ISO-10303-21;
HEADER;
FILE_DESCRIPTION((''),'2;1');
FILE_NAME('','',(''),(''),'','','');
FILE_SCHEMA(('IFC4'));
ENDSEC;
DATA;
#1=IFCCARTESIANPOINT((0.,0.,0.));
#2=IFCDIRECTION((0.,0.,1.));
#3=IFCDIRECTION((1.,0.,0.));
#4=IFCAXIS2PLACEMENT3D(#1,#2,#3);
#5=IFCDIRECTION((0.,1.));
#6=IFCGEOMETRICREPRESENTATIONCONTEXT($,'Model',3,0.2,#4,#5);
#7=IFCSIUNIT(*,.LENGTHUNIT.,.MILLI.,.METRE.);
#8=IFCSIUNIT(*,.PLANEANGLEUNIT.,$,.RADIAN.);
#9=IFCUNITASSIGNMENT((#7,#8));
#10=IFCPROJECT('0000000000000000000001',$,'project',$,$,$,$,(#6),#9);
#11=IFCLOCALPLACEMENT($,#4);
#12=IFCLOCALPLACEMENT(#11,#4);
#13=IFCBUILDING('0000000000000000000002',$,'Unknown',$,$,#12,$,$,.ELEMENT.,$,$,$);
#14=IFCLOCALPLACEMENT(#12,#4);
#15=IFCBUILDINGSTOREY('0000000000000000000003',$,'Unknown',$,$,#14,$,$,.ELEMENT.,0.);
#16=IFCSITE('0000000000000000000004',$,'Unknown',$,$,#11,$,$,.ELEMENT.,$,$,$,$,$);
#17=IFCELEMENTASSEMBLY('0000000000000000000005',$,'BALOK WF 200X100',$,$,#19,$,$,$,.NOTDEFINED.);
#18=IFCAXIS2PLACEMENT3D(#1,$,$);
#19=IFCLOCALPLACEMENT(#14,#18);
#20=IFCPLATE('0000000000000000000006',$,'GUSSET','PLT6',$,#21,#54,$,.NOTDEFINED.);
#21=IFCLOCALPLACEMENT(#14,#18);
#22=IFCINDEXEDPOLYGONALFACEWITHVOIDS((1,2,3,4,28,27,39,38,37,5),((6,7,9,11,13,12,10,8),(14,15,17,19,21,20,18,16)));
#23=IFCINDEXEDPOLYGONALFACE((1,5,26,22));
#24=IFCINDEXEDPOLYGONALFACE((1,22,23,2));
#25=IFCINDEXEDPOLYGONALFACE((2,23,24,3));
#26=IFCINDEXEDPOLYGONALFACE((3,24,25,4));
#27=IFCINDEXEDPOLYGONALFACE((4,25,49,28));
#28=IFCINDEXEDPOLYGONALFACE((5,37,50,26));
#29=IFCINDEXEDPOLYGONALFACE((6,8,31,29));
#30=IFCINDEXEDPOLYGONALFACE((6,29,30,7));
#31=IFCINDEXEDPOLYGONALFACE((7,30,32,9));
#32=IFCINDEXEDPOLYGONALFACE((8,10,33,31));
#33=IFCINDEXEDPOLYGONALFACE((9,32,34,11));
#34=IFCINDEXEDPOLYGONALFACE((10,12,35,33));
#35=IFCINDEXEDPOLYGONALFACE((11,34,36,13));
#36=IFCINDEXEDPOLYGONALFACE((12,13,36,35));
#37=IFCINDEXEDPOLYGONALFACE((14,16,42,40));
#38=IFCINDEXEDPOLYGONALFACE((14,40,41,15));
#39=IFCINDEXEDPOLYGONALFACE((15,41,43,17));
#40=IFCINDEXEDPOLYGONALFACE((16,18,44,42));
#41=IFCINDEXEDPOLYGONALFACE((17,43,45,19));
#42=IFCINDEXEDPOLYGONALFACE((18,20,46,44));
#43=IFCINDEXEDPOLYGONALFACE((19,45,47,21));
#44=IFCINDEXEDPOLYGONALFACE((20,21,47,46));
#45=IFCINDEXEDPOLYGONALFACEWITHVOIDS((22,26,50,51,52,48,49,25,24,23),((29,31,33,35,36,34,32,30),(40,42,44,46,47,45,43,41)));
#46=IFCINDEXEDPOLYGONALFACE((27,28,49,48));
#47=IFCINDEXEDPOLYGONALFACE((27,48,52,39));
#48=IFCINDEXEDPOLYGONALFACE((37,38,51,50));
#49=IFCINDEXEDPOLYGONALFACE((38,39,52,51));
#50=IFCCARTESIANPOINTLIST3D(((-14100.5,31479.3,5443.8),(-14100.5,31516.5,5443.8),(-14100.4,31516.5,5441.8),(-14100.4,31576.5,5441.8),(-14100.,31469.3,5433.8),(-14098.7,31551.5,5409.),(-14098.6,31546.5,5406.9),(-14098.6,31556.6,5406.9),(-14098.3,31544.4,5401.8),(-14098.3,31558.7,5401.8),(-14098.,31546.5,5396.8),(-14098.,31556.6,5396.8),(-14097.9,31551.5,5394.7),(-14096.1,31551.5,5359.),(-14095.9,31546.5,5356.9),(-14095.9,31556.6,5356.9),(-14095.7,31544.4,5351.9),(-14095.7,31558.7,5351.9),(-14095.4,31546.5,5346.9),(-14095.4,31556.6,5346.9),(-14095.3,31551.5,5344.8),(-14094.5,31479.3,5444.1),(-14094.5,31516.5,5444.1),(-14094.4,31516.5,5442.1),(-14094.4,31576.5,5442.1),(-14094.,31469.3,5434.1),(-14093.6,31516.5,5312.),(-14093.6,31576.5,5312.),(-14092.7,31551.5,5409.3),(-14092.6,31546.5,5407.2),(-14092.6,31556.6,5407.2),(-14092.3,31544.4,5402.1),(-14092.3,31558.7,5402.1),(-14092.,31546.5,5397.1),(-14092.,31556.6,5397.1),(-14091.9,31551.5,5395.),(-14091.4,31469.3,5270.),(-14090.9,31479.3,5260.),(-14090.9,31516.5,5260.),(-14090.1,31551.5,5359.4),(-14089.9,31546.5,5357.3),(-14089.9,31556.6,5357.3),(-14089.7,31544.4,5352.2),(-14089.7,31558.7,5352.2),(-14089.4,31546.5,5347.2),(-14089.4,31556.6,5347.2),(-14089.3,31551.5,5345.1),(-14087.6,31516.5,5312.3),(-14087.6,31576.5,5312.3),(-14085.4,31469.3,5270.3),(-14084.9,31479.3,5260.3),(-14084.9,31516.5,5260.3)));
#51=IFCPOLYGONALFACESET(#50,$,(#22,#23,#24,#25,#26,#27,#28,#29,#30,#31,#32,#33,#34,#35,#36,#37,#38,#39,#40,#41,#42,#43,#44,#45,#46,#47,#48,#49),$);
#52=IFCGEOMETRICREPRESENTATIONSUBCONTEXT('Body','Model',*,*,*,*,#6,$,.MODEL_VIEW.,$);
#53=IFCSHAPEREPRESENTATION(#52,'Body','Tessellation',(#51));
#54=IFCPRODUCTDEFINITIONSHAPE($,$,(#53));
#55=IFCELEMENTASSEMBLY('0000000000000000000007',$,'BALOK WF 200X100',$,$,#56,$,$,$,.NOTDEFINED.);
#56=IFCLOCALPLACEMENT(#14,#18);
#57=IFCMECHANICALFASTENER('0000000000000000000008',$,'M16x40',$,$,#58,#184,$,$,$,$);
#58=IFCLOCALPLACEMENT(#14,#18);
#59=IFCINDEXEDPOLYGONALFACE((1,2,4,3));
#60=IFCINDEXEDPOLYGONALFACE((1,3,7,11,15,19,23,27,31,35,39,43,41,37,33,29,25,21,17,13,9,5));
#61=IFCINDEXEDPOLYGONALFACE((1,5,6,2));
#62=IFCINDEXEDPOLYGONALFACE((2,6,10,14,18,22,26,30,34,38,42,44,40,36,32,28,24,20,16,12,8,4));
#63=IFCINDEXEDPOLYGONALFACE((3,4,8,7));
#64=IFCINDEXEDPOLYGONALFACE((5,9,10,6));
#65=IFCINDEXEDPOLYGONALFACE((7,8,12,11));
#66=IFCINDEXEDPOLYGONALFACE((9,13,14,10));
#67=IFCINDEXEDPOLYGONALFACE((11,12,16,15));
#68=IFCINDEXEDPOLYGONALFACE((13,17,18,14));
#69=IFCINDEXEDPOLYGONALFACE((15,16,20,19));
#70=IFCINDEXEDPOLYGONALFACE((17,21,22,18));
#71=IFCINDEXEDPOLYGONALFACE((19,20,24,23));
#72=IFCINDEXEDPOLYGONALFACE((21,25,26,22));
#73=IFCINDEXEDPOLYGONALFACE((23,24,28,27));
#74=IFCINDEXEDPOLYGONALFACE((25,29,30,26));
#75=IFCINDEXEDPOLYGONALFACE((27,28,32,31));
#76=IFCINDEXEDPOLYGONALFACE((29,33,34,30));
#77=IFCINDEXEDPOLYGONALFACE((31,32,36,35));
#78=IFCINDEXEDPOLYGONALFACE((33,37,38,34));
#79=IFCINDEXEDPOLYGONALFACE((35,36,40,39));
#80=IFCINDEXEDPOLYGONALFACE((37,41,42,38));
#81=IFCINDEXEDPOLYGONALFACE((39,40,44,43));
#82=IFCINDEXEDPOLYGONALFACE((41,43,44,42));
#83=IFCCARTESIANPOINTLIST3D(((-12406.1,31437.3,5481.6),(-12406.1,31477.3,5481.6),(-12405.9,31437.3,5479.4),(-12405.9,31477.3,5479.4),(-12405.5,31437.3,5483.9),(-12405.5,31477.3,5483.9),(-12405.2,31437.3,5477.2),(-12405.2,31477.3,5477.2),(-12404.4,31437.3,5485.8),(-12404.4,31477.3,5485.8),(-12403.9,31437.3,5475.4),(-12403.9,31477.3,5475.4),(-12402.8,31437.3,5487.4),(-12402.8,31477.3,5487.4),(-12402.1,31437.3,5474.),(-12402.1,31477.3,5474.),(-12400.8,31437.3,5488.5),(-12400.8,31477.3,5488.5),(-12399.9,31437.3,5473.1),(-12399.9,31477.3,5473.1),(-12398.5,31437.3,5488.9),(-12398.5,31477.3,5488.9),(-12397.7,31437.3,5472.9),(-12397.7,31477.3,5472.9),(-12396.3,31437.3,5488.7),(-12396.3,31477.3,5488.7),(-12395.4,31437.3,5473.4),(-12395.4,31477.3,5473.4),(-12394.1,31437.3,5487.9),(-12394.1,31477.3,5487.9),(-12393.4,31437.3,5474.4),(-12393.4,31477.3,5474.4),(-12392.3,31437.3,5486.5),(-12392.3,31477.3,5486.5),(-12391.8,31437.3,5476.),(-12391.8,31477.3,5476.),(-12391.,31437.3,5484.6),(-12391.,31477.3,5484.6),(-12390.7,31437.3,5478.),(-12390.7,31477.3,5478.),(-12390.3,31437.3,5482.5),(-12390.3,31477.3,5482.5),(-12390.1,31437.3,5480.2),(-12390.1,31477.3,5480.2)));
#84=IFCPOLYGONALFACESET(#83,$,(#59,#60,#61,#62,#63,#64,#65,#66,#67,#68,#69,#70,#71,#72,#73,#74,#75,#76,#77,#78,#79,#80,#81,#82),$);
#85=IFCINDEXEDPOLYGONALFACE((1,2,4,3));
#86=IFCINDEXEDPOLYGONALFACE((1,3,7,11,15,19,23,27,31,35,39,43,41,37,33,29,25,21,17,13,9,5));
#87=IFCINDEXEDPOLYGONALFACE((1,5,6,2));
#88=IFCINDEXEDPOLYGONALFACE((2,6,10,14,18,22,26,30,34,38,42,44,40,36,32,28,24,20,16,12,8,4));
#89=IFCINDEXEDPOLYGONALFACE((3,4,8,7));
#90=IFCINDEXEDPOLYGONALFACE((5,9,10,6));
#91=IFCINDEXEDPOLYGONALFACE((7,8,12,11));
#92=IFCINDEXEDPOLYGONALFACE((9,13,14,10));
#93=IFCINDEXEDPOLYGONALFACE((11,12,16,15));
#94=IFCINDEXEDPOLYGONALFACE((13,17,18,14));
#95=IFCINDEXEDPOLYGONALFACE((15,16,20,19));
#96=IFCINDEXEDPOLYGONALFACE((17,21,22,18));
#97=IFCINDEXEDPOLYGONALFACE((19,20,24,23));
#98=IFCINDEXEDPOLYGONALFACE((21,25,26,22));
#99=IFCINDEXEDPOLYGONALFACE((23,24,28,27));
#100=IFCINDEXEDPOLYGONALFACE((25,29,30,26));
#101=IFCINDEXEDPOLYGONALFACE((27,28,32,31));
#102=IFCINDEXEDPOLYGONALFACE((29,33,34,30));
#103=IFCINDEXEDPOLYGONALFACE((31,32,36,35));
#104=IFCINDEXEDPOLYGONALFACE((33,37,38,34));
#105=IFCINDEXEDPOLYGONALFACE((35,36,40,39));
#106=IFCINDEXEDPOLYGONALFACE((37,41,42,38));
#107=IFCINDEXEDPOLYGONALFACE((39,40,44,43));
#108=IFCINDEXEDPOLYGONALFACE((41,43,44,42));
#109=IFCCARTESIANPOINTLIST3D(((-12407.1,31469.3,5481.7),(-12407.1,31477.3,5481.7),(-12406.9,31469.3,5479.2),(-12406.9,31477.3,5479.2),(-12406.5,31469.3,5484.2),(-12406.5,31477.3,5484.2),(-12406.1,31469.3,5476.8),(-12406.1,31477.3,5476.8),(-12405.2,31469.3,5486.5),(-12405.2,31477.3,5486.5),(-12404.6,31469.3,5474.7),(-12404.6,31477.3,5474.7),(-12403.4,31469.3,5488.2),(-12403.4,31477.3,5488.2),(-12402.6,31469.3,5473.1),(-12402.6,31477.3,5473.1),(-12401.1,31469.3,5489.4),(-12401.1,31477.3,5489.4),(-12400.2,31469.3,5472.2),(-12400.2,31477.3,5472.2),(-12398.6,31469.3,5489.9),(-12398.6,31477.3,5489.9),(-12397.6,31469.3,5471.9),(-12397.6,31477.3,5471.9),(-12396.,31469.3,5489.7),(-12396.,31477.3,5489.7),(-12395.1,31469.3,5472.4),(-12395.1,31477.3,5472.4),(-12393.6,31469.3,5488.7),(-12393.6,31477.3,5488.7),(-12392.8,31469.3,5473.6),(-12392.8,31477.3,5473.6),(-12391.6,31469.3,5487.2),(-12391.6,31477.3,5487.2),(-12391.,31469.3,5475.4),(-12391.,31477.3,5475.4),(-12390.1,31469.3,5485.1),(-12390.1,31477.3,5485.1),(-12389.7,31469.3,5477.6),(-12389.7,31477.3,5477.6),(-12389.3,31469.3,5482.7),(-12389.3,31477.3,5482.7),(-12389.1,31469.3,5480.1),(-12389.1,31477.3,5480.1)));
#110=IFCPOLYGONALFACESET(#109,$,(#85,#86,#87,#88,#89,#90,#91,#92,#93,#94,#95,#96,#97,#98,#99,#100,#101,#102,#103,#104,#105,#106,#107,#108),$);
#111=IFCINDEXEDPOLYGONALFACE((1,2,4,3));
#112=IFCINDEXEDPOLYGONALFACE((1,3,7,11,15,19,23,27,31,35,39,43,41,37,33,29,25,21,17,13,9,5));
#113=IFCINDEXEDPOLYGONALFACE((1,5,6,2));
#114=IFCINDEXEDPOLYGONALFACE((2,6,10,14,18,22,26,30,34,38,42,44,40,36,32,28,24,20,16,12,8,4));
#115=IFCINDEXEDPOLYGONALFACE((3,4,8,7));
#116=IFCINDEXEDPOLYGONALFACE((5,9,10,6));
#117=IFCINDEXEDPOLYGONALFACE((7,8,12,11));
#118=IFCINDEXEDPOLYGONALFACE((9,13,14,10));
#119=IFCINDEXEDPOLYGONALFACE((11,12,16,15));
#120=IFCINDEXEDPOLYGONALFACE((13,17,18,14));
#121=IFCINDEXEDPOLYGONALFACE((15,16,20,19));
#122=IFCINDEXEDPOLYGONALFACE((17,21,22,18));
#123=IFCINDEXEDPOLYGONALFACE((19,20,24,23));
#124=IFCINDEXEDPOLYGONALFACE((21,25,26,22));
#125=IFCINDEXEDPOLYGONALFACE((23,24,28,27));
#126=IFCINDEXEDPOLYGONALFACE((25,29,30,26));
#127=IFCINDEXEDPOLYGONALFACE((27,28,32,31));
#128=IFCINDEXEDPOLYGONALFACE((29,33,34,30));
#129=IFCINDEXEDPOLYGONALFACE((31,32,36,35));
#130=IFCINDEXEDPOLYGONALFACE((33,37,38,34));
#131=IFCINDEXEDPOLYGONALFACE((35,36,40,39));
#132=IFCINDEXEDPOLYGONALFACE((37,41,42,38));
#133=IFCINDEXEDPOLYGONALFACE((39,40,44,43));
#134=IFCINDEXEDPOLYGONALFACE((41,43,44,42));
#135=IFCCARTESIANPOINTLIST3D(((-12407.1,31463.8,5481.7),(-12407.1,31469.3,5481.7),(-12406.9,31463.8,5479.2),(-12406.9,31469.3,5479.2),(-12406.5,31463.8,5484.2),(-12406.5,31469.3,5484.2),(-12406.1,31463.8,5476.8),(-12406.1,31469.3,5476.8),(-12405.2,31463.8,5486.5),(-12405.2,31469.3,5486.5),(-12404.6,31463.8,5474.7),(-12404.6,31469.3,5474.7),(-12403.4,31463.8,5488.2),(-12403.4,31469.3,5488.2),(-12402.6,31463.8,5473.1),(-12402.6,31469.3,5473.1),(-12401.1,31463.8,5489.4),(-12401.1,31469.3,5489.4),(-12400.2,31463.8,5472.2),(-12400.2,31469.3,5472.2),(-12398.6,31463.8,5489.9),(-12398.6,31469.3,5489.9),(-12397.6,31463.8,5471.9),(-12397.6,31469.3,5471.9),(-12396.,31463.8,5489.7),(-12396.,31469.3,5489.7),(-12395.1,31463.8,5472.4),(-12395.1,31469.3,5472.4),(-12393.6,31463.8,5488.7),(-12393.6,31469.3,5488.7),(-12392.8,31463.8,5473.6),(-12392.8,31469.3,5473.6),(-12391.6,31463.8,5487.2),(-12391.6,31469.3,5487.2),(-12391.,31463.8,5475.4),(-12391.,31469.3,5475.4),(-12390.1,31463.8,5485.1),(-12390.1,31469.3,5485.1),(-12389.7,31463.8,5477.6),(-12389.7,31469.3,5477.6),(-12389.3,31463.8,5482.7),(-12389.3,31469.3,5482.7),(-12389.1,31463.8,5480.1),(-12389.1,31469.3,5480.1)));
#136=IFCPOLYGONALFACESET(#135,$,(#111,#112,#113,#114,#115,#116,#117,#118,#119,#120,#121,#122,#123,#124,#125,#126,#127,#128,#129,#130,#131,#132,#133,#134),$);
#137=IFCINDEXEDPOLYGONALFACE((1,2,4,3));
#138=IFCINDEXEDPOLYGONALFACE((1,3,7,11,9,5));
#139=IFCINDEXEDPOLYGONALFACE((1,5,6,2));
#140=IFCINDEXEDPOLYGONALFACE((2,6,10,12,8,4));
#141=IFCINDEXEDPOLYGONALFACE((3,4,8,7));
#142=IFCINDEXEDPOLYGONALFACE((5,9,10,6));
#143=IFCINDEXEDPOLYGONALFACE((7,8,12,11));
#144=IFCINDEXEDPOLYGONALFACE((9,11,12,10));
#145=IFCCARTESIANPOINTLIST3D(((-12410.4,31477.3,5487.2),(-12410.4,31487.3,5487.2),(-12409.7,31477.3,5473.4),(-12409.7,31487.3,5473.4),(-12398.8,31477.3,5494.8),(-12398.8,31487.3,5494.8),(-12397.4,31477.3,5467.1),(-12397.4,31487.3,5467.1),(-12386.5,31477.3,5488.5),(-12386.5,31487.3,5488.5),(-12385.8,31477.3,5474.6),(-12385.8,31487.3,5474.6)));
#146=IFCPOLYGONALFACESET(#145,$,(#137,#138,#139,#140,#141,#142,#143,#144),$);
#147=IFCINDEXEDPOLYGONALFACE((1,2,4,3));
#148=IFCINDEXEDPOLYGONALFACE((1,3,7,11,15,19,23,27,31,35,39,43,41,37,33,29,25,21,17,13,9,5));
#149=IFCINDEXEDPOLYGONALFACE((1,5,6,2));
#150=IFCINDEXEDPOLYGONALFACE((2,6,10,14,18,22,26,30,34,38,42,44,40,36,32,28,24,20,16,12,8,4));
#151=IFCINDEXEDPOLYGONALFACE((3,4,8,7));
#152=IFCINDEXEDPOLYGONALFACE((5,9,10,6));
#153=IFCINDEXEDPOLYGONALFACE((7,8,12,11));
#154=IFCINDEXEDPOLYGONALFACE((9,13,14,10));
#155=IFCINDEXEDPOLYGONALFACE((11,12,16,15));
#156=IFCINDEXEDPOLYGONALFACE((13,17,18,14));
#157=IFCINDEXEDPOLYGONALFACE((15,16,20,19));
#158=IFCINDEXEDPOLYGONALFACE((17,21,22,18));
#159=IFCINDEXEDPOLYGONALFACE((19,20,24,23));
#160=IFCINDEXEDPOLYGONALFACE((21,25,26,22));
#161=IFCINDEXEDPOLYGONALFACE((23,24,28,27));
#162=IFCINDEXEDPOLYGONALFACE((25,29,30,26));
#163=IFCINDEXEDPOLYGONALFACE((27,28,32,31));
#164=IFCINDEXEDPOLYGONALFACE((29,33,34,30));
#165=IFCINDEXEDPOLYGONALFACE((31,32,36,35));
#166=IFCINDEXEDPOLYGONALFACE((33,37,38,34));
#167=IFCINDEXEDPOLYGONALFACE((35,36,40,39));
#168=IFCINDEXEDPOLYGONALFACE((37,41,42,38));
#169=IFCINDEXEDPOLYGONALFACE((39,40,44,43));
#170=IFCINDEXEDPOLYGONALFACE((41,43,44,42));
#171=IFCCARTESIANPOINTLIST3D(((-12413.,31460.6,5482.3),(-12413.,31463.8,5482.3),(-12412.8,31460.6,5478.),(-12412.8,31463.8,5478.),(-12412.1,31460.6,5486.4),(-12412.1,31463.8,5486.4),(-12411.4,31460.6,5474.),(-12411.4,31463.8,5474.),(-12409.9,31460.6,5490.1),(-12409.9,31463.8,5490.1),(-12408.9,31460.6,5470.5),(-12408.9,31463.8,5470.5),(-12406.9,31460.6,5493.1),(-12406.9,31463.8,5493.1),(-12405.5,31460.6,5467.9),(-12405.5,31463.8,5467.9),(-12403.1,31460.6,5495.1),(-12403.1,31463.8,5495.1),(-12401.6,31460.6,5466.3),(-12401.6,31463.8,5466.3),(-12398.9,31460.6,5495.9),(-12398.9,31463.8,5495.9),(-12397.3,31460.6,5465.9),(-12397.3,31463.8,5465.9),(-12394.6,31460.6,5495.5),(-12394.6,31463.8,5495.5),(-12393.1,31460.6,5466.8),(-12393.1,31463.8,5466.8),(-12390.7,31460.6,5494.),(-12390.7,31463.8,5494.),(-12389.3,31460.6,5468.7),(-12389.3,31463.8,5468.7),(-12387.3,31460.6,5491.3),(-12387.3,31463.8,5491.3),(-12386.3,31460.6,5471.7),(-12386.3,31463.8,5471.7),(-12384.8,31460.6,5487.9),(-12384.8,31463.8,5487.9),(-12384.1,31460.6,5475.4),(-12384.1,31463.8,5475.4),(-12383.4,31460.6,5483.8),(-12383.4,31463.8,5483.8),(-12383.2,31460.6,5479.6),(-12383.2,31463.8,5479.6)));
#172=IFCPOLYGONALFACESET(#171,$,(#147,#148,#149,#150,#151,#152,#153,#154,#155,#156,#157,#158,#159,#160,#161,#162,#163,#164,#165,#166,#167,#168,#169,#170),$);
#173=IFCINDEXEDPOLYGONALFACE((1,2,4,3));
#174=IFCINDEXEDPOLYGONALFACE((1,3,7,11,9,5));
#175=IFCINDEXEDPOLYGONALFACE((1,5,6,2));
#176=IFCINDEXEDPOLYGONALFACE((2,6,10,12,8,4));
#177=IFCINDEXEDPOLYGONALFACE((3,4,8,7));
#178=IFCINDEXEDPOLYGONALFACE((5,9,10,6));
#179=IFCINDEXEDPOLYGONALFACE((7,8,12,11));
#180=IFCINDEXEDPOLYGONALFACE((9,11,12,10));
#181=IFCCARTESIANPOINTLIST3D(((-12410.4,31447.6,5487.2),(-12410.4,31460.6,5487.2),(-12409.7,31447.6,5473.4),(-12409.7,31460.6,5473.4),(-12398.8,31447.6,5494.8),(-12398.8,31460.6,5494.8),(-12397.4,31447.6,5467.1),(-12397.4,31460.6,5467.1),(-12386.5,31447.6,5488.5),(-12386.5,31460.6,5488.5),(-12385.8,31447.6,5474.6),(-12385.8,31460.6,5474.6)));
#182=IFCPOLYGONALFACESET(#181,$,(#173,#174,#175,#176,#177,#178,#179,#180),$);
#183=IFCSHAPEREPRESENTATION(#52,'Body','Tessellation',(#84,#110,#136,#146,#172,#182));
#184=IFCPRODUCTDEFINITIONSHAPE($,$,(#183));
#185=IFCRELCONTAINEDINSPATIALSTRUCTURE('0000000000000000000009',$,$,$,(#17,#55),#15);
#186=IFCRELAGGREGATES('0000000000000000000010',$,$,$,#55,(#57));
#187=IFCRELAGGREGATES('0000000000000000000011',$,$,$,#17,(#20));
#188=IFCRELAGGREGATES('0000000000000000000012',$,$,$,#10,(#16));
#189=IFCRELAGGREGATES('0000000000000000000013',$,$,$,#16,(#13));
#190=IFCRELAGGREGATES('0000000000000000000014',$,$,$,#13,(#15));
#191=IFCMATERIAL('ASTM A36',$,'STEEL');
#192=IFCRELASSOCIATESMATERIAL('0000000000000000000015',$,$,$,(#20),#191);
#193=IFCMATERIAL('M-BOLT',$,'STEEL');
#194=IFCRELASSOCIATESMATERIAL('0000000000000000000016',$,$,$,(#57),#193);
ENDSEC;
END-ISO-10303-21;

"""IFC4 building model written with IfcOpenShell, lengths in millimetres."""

from ifc_helpers import new_model, si_unit, direction, frame, origin_with_axes, place, context, subcontext, project, spatial, line, arc, indexed_curve, outline, extrude, source, transform, mapped, material, element, aggregate, save


model = new_model("IFC4")

# Units and contexts
model_context = context("Model", 3, precision=0.2, world=origin_with_axes(), true_north=direction((0.0, 1.0)))
body_context = subcontext(model_context, "Body", "Model", "MODEL_VIEW")
ifc_project = project(units=[si_unit("LENGTHUNIT", "METRE", prefix="MILLI"), si_unit("PLANEANGLEUNIT", "RADIAN")], contexts=[model_context])

# Site, building, storey
site_placement = place(None, origin_with_axes())
site = spatial("IfcSite", under=ifc_project, at=site_placement, Name="Unknown", CompositionType="ELEMENT")
building_placement = place(site_placement, origin_with_axes())
building = spatial("IfcBuilding", under=site, at=building_placement, Name="Unknown", CompositionType="ELEMENT")
storey_placement = place(building_placement, origin_with_axes())
storey = spatial("IfcBuildingStorey", under=building, at=storey_placement, Name="Unknown", CompositionType="ELEMENT", Elevation=0.0)

# Element assembly
assembly_1_placement = place(storey_placement, frame((-12608.3, 31466.5, 5421.2), z_axis=(0.0, 1.0, 0.0), x_axis=(-0.998912, 0.0, -0.046636)))
assembly_1 = element("IfcElementAssembly", 1, at=assembly_1_placement, inside=storey, Name="BALOK WF 200X100", PredefinedType="NOTDEFINED")

# Shared definitions
ifc_material_1 = material(Name="ASTM A36", Category="STEEL")

# Plate, voiding features
plate_1_placement = place(assembly_1_placement, frame((1486.5, 92.2, 2.8), z_axis=(0.999984, -0.005707, 0.0), x_axis=(0.0, 0.0, 1.0)))
plate_1 = element("IfcPlate", 2, at=plate_1_placement, material=ifc_material_1, Name="GUSSET", Description="PLT6", PredefinedType="NOTDEFINED", context=body_context, shape_type="SolidModel", body=[
    extrude(outline(indexed_curve([(0.0, 0.0), (47.2, 0.0), (47.2, 2.0), (107.3, 2.0), (107.3, 132.0), (47.2, 132.0), (47.2, 184.0), (0.0, 184.0)], segments=[line(1, 2, 3, 4, 5, 6, 7, 8, 1)])), frame((0.0, 0.0, 3.0), z_axis=(0.0, 0.0, 1.0), x_axis=(1.0, 0.0, 0.0)), (0.0, 0.0, -1.0), 6.0),
])
voiding_feature_1_placement = place(plate_1_placement, frame((10.0, 0.0, 0.0), z_axis=(0.0, 0.0, 1.0), x_axis=(-0.707107, 0.707107, 0.0)))
element("IfcVoidingFeature", 3, at=voiding_feature_1_placement, cuts=plate_1, Name="SLAB", PredefinedType="HOLE", context=body_context, shape_type="SolidModel", body=[
    extrude(outline(indexed_curve([(0.0, 0.0), (14.1, 0.0), (7.1, 7.1)], segments=[line(1, 2, 3, 1)])), frame((0.0, 0.0, 3.0), z_axis=(0.0, 0.0, 1.0), x_axis=(1.0, 0.0, 0.0)), (0.0, 0.0, -1.0), 6.0),
])
voiding_feature_2_placement = place(plate_1_placement, frame((0.0, 174.0, 0.0), z_axis=(0.0, 0.0, 1.0), x_axis=(0.707107, 0.707107, 0.0)))
element("IfcVoidingFeature", 4, at=voiding_feature_2_placement, cuts=plate_1, Name="SLAB", PredefinedType="HOLE", context=body_context, shape_type="SolidModel", body=[
    extrude(outline(indexed_curve([(0.0, 0.0), (14.1, 0.0), (7.1, 7.1)], segments=[line(1, 2, 3, 1)])), frame((0.0, 0.0, 3.0), z_axis=(0.0, 0.0, 1.0), x_axis=(1.0, 0.0, 0.0)), (0.0, 0.0, -1.0), 6.0),
])
voiding_feature_3_placement = place(plate_1_placement, frame((82.3, 92.0, -3.5), z_axis=(-1.0, 0.0, 0.0), x_axis=(0.0, 0.0, 1.0)))
element("IfcVoidingFeature", 5, at=voiding_feature_3_placement, cuts=plate_1, Name="BEAM", PredefinedType="HOLE", context=body_context, shape_type="SolidModel", body=[
    extrude(outline(indexed_curve([(7.1, 0.0), (5.1, 5.1), (0.0, 7.1), (-5.1, 5.1), (-7.1, 0.0), (-5.1, -5.1), (0.0, -7.1), (5.1, -5.1)], segments=[line(1, 2, 3, 4, 5, 6, 7, 8, 1)])), frame((0.0, 0.0, 0.0), z_axis=(-1.0, 0.0, 0.0), x_axis=(0.0, 0.0, 1.0)), (0.0, 0.0, -1.0), 7.0),
])
voiding_feature_4_placement = place(plate_1_placement, frame((82.3, 42.0, -3.5), z_axis=(-1.0, 0.0, 0.0), x_axis=(0.0, 0.0, 1.0)))
element("IfcVoidingFeature", 6, at=voiding_feature_4_placement, cuts=plate_1, Name="BEAM", PredefinedType="HOLE", context=body_context, shape_type="SolidModel", body=[
    extrude(outline(indexed_curve([(7.1, 0.0), (5.1, 5.1), (0.0, 7.1), (-5.1, 5.1), (-7.1, 0.0), (-5.1, -5.1), (0.0, -7.1), (5.1, -5.1)], segments=[line(1, 2, 3, 4, 5, 6, 7, 8, 1)])), frame((0.0, 0.0, 0.0), z_axis=(-1.0, 0.0, 0.0), x_axis=(0.0, 0.0, 1.0)), (0.0, 0.0, -1.0), 7.0),
])

# Element assembly, mechanical fastener
assembly_2_placement = place(storey_placement, frame((-7044.1, 31466.5, 5721.5), z_axis=(0.0, 1.0, 0.0), x_axis=(-0.99863, 0.0, -0.052336)))
assembly_2 = element("IfcElementAssembly", 7, at=assembly_2_placement, inside=storey, Name="BALOK WF 200X100", PredefinedType="NOTDEFINED")
ifc_material_2 = material(Name="M-BOLT", Category="STEEL")
shared_shape_1 = source(origin_with_axes(), body_context, "Body", "SweptSolid", [
    extrude(outline(indexed_curve([(8.0, 0.0), (0.0, 8.0), (-8.0, 0.0), (0.0, -8.0)], segments=[arc(1, 2, 3), arc(3, 4, 1)])), frame((0.0, 0.0, 0.0), z_axis=(0.0, 0.0, -1.0), x_axis=(0.0, 1.0, 0.0)), (0.0, 0.0, 1.0), 40.0),
    extrude(outline(indexed_curve([(9.0, 0.0), (0.0, 9.0), (-9.0, 0.0), (0.0, -9.0)], segments=[arc(1, 2, 3), arc(3, 4, 1)])), frame((0.0, 0.0, 0.0), z_axis=(0.0, 0.0, -1.0), x_axis=(0.0, 1.0, 0.0)), (0.0, 0.0, 1.0), 8.0),
    extrude(outline(indexed_curve([(9.0, 0.0), (0.0, 9.0), (-9.0, 0.0), (0.0, -9.0)], segments=[arc(1, 2, 3), arc(3, 4, 1)])), frame((0.0, 0.0, -8.0), z_axis=(0.0, 0.0, -1.0), x_axis=(0.0, 1.0, 0.0)), (0.0, 0.0, 1.0), 5.5),
    extrude(outline(indexed_curve([(13.9, 0.0), (6.9, 12.0), (-6.9, 12.0), (-13.9, 0.0), (-6.9, -12.0), (6.9, -12.0)], segments=[line(1, 2, 3, 4, 5, 6, 1)])), frame((0.0, 0.0, 10.0), z_axis=(0.0, 0.0, -1.0), x_axis=(0.0, 1.0, 0.0)), (0.0, 0.0, 1.0), 10.0),
    extrude(outline(indexed_curve([(15.0, 0.0), (0.0, 15.0), (-15.0, 0.0), (0.0, -15.0)], segments=[arc(1, 2, 3), arc(3, 4, 1)])), frame((0.0, 0.0, -13.5), z_axis=(0.0, 0.0, -1.0), x_axis=(0.0, 1.0, 0.0)), (0.0, 0.0, 1.0), 3.2),
    extrude(outline(indexed_curve([(13.9, 0.0), (6.9, 12.0), (-6.9, 12.0), (-13.9, 0.0), (-6.9, -12.0), (6.9, -12.0)], segments=[line(1, 2, 3, 4, 5, 6, 1)])), frame((0.0, 0.0, -16.7), z_axis=(0.0, 0.0, -1.0), x_axis=(0.0, 1.0, 0.0)), (0.0, 0.0, 1.0), 13.0),
])
mechanical_fastener_1_placement = place(assembly_2_placement, frame((5359.2, 40.0, 10.7), z_axis=(-0.000004, 0.0, 1.0), x_axis=(-1.0, 0.0, -0.000004)))
mechanical_fastener_1 = element("IfcMechanicalFastener", 8, at=mechanical_fastener_1_placement, material=ifc_material_2, Name="M16x40", context=body_context, shape_type="MappedRepresentation", body=[
    mapped(shared_shape_1, transform((0.0, 0.0, 0.0))),
])
aggregate(assembly_2, [mechanical_fastener_1])

aggregate(assembly_1, [plate_1])

save(model, "model.ifc")
